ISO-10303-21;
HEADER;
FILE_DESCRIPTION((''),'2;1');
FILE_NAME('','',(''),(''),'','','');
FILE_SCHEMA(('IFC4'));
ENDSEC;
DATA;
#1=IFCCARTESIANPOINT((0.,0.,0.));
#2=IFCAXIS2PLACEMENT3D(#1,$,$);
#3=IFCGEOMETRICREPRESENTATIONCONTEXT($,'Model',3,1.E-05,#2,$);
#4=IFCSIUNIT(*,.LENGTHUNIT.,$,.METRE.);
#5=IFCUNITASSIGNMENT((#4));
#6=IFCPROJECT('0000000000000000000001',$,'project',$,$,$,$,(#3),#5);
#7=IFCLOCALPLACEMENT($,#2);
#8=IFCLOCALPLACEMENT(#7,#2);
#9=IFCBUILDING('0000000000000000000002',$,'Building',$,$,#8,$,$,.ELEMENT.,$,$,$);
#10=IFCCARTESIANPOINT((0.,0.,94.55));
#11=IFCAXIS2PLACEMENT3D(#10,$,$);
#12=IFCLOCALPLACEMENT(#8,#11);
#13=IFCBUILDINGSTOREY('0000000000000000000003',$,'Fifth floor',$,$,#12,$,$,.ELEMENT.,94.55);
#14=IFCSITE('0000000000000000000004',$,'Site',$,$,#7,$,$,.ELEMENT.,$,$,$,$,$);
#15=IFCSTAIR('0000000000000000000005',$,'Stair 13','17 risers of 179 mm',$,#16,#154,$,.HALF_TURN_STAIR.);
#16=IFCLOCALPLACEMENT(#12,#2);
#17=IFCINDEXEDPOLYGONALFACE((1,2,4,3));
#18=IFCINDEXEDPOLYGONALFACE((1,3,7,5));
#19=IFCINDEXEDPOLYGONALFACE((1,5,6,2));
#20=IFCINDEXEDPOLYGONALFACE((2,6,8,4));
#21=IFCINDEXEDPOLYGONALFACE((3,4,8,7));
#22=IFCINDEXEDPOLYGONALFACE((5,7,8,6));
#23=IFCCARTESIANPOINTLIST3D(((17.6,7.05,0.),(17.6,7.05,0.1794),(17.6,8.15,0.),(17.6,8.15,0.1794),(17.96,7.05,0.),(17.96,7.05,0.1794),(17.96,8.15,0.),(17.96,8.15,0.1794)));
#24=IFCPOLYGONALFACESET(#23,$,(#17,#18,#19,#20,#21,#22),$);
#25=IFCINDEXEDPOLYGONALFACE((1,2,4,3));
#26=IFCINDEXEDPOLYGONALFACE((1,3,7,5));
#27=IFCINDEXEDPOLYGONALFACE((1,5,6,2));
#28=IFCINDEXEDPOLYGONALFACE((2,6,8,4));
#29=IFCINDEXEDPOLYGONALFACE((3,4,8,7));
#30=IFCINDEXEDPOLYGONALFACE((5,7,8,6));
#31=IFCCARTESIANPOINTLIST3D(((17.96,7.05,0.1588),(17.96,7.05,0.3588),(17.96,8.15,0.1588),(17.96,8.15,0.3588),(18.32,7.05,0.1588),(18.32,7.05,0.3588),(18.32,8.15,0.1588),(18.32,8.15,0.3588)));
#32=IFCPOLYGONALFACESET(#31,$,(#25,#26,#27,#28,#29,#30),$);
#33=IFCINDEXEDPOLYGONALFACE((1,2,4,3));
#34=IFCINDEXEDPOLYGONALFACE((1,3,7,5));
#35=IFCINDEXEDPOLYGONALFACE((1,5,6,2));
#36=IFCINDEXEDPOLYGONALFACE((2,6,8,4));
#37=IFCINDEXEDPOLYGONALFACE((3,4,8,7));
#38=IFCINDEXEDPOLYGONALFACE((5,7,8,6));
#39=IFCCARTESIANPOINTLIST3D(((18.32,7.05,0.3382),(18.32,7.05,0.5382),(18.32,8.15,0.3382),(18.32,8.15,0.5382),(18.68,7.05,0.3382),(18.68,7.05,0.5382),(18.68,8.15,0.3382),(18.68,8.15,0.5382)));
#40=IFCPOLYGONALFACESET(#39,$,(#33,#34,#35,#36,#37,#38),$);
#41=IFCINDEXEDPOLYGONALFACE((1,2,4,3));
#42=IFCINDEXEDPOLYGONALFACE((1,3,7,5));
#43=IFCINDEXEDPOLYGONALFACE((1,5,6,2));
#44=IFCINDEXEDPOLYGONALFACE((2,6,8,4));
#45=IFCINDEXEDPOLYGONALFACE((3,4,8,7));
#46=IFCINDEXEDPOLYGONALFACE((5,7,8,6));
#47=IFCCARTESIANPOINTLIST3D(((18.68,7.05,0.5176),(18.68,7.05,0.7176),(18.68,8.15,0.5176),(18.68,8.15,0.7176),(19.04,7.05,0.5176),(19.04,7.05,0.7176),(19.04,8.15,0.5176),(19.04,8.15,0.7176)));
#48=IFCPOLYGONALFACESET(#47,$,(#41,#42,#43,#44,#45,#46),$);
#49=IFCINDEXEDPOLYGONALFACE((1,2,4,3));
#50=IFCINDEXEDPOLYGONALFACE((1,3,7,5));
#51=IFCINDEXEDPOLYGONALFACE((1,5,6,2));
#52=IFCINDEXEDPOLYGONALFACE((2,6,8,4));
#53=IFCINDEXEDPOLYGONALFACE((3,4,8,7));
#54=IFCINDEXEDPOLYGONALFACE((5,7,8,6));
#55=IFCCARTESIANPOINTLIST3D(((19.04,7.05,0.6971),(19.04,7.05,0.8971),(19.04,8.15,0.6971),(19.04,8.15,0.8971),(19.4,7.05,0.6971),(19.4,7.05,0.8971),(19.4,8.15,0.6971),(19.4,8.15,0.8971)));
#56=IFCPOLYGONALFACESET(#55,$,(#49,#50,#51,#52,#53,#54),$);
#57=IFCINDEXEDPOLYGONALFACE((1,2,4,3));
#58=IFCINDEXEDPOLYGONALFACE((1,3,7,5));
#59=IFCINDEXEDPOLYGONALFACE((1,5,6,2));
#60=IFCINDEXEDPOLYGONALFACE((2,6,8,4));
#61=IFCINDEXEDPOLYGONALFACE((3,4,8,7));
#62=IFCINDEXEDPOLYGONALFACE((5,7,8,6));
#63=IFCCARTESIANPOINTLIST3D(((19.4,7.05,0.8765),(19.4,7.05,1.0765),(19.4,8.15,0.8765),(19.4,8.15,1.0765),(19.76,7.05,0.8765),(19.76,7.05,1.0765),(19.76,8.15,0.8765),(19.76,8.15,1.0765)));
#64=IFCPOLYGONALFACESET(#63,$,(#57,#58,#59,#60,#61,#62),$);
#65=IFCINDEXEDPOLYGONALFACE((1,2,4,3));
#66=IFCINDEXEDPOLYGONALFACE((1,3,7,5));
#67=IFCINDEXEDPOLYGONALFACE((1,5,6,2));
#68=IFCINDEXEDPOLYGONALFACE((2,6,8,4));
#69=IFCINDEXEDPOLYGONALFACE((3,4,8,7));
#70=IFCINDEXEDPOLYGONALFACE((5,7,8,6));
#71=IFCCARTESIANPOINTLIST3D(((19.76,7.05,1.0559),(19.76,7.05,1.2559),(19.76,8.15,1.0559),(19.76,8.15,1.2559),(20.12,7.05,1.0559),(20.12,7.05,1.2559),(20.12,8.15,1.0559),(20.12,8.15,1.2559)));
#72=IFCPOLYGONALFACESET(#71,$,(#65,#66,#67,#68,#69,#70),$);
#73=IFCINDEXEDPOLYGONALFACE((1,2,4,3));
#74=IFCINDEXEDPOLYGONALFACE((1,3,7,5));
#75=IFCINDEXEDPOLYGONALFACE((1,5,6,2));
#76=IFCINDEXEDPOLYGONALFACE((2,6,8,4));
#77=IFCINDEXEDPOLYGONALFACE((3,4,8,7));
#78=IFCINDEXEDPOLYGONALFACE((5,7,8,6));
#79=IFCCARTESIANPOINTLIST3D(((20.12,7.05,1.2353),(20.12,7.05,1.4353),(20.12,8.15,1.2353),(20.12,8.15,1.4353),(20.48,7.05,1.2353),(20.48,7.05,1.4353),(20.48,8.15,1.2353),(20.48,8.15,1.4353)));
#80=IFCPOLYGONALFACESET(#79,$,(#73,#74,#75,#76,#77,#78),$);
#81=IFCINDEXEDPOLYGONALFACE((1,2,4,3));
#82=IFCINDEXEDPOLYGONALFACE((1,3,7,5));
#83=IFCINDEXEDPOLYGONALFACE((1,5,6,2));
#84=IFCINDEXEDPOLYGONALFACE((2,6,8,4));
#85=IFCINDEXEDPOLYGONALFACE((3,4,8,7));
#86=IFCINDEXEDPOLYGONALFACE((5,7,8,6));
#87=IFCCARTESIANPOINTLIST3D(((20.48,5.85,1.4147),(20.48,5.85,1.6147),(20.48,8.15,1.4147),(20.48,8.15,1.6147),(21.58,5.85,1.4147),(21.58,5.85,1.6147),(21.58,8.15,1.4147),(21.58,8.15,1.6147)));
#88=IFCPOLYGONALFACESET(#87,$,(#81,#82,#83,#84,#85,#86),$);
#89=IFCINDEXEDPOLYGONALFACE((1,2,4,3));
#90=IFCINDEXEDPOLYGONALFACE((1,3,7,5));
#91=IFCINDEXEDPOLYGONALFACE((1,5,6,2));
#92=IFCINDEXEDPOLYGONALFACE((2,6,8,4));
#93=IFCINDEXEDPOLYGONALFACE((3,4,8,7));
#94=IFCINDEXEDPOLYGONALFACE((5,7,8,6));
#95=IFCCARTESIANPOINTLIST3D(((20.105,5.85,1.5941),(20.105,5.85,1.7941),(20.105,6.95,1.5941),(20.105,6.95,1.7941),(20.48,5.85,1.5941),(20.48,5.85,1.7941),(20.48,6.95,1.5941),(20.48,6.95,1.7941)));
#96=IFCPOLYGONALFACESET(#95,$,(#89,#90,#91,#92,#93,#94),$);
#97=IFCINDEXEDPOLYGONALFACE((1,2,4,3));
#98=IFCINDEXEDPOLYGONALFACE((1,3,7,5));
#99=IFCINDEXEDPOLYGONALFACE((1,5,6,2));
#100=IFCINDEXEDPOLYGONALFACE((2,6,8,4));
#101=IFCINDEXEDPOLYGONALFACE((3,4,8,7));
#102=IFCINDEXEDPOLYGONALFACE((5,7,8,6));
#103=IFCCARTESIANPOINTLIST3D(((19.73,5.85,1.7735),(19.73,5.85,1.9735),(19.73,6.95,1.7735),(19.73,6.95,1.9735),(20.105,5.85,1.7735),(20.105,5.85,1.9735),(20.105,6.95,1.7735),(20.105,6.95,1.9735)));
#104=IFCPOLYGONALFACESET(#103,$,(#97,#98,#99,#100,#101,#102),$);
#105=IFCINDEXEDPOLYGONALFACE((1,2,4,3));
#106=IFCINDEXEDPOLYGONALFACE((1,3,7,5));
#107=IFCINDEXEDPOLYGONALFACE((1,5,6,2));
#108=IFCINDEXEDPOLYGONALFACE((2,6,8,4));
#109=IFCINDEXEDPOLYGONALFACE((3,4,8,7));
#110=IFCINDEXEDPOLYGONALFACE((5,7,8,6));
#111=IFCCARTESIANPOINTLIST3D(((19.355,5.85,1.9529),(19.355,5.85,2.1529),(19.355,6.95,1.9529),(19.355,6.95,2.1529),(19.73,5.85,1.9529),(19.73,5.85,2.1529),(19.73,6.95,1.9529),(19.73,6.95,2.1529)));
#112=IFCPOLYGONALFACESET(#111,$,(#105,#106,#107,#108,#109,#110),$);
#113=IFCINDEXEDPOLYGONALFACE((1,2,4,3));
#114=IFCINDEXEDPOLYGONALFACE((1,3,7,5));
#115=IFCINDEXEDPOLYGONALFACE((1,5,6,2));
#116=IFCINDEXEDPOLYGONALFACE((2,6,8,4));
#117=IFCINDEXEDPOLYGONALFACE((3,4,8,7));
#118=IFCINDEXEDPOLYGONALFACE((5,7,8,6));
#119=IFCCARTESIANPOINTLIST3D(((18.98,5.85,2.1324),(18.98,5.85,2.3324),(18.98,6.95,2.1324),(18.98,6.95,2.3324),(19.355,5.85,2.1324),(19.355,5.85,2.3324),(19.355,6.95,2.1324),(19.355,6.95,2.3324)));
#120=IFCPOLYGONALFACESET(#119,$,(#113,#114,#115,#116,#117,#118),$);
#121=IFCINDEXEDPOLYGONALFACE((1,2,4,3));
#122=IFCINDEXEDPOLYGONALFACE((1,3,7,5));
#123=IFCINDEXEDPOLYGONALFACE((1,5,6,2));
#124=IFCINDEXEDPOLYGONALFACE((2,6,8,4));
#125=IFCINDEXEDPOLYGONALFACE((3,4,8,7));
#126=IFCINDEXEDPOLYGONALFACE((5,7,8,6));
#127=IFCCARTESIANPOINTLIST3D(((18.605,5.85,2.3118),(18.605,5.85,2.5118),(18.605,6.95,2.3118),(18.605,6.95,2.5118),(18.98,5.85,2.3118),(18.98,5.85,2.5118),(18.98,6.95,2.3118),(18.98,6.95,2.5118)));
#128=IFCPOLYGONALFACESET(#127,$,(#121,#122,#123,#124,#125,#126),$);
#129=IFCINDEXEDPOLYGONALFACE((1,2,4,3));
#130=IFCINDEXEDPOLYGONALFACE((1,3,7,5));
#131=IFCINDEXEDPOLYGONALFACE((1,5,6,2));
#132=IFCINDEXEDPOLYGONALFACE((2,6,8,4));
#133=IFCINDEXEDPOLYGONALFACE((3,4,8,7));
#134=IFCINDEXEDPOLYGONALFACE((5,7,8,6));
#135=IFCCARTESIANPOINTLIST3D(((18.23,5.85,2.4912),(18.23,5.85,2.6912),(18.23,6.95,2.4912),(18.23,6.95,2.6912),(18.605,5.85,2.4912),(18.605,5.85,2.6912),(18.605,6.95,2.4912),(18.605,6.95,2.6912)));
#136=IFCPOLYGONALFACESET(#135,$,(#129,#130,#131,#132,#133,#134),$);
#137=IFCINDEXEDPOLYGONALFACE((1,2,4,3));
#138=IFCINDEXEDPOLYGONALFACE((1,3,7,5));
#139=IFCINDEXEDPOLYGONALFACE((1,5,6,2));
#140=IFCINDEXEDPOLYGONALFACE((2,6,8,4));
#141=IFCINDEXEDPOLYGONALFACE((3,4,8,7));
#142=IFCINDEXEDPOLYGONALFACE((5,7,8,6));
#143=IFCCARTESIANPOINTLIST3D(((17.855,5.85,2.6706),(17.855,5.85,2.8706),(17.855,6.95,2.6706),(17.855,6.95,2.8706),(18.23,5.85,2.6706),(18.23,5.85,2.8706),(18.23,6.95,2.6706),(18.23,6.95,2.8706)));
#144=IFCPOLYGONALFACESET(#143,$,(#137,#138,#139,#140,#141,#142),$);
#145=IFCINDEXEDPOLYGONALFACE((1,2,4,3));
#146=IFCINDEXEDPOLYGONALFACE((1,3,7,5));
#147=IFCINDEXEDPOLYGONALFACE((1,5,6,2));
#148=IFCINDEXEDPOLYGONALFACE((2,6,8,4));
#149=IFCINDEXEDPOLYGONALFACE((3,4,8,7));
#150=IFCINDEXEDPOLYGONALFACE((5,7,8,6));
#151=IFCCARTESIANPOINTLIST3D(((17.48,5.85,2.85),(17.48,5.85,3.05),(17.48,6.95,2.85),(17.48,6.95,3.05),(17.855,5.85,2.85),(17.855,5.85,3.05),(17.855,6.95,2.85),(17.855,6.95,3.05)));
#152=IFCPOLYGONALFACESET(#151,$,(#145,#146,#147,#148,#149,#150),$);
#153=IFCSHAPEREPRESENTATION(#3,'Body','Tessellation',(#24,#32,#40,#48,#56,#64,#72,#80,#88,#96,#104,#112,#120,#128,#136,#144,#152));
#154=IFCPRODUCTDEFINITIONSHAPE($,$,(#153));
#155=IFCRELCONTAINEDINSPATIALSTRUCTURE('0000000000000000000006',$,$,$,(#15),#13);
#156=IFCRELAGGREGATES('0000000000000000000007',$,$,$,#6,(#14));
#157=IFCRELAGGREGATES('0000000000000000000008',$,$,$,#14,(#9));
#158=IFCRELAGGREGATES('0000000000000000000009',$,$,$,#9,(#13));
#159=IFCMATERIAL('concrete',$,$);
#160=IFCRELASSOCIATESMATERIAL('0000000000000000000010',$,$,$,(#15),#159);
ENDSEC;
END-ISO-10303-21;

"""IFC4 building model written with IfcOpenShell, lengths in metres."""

from ifc_helpers import new_model, si_unit, frame, origin, place, context, project, spatial, polyline, outline, extrude, material, element, save


model = new_model("IFC4")

# Units and contexts
model_context = context("Model", 3, precision=1e-05, world=origin())
ifc_project = project(units=[si_unit("LENGTHUNIT", "METRE")], contexts=[model_context])

# Site, building, storey
site_placement = place(None, origin())
site = spatial("IfcSite", under=ifc_project, at=site_placement, Name="Site", CompositionType="ELEMENT")
building_placement = place(site_placement, origin())
building = spatial("IfcBuilding", under=site, at=building_placement, Name="Building", CompositionType="ELEMENT")
storey_placement = place(building_placement, frame((0.0, 0.0, 94.55)))
storey = spatial("IfcBuildingStorey", under=building, at=storey_placement, Name="Fifth floor", CompositionType="ELEMENT", Elevation=94.55)

# Shared definitions
ifc_material = material(Name="concrete")

# Stair
stair_1_placement = place(storey_placement, frame((17.6, 7.6, 0.0), z_axis=(0.0, 0.0, 1.0), x_axis=(1.0, 0.0, 0.0)))
element("IfcStair", 1, at=stair_1_placement, inside=storey, material=ifc_material, Name="Stair 13", Description="17 risers of 179 mm", PredefinedType="HALF_TURN_STAIR", context=model_context, shape_type="SweptSolid", body=[
    extrude(outline(polyline([(0.0, -0.55), (0.36, -0.55), (0.36, 0.55), (0.0, 0.55), (0.0, -0.55)])), origin(), (0.0, 0.0, 1.0), 0.1794),
    extrude(outline(polyline([(0.36, -0.55), (0.72, -0.55), (0.72, 0.55), (0.36, 0.55), (0.36, -0.55)])), frame((0.0, 0.0, 0.1588)), (0.0, 0.0, 1.0), 0.2),
    extrude(outline(polyline([(0.72, -0.55), (1.08, -0.55), (1.08, 0.55), (0.72, 0.55), (0.72, -0.55)])), frame((0.0, 0.0, 0.3382)), (0.0, 0.0, 1.0), 0.2),
    extrude(outline(polyline([(1.08, -0.55), (1.44, -0.55), (1.44, 0.55), (1.08, 0.55), (1.08, -0.55)])), frame((0.0, 0.0, 0.5176)), (0.0, 0.0, 1.0), 0.2),
    extrude(outline(polyline([(1.44, -0.55), (1.8, -0.55), (1.8, 0.55), (1.44, 0.55), (1.44, -0.55)])), frame((0.0, 0.0, 0.6971)), (0.0, 0.0, 1.0), 0.2),
    extrude(outline(polyline([(1.8, -0.55), (2.16, -0.55), (2.16, 0.55), (1.8, 0.55), (1.8, -0.55)])), frame((0.0, 0.0, 0.8765)), (0.0, 0.0, 1.0), 0.2),
    extrude(outline(polyline([(2.16, -0.55), (2.52, -0.55), (2.52, 0.55), (2.16, 0.55), (2.16, -0.55)])), frame((0.0, 0.0, 1.0559)), (0.0, 0.0, 1.0), 0.2),
    extrude(outline(polyline([(2.52, -0.55), (2.88, -0.55), (2.88, 0.55), (2.52, 0.55), (2.52, -0.55)])), frame((0.0, 0.0, 1.2353)), (0.0, 0.0, 1.0), 0.2),
    extrude(outline(polyline([(2.88, -1.75), (3.98, -1.75), (3.98, 0.55), (2.88, 0.55), (2.88, -1.75)])), frame((0.0, 0.0, 1.4147)), (0.0, 0.0, 1.0), 0.2),
    extrude(outline(polyline([(2.505, -1.75), (2.88, -1.75), (2.88, -0.65), (2.505, -0.65), (2.505, -1.75)])), frame((0.0, 0.0, 1.5941)), (0.0, 0.0, 1.0), 0.2),
    extrude(outline(polyline([(2.13, -1.75), (2.505, -1.75), (2.505, -0.65), (2.13, -0.65), (2.13, -1.75)])), frame((0.0, 0.0, 1.7735)), (0.0, 0.0, 1.0), 0.2),
    extrude(outline(polyline([(1.755, -1.75), (2.13, -1.75), (2.13, -0.65), (1.755, -0.65), (1.755, -1.75)])), frame((0.0, 0.0, 1.9529)), (0.0, 0.0, 1.0), 0.2),
    extrude(outline(polyline([(1.38, -1.75), (1.755, -1.75), (1.755, -0.65), (1.38, -0.65), (1.38, -1.75)])), frame((0.0, 0.0, 2.1324)), (0.0, 0.0, 1.0), 0.2),
    extrude(outline(polyline([(1.005, -1.75), (1.38, -1.75), (1.38, -0.65), (1.005, -0.65), (1.005, -1.75)])), frame((0.0, 0.0, 2.3118)), (0.0, 0.0, 1.0), 0.2),
    extrude(outline(polyline([(0.63, -1.75), (1.005, -1.75), (1.005, -0.65), (0.63, -0.65), (0.63, -1.75)])), frame((0.0, 0.0, 2.4912)), (0.0, 0.0, 1.0), 0.2),
    extrude(outline(polyline([(0.255, -1.75), (0.63, -1.75), (0.63, -0.65), (0.255, -0.65), (0.255, -1.75)])), frame((0.0, 0.0, 2.6706)), (0.0, 0.0, 1.0), 0.2),
    extrude(outline(polyline([(-0.12, -1.75), (0.255, -1.75), (0.255, -0.65), (-0.12, -0.65), (-0.12, -1.75)])), frame((0.0, 0.0, 2.85)), (0.0, 0.0, 1.0), 0.2),
])

save(model, "model.ifc")
